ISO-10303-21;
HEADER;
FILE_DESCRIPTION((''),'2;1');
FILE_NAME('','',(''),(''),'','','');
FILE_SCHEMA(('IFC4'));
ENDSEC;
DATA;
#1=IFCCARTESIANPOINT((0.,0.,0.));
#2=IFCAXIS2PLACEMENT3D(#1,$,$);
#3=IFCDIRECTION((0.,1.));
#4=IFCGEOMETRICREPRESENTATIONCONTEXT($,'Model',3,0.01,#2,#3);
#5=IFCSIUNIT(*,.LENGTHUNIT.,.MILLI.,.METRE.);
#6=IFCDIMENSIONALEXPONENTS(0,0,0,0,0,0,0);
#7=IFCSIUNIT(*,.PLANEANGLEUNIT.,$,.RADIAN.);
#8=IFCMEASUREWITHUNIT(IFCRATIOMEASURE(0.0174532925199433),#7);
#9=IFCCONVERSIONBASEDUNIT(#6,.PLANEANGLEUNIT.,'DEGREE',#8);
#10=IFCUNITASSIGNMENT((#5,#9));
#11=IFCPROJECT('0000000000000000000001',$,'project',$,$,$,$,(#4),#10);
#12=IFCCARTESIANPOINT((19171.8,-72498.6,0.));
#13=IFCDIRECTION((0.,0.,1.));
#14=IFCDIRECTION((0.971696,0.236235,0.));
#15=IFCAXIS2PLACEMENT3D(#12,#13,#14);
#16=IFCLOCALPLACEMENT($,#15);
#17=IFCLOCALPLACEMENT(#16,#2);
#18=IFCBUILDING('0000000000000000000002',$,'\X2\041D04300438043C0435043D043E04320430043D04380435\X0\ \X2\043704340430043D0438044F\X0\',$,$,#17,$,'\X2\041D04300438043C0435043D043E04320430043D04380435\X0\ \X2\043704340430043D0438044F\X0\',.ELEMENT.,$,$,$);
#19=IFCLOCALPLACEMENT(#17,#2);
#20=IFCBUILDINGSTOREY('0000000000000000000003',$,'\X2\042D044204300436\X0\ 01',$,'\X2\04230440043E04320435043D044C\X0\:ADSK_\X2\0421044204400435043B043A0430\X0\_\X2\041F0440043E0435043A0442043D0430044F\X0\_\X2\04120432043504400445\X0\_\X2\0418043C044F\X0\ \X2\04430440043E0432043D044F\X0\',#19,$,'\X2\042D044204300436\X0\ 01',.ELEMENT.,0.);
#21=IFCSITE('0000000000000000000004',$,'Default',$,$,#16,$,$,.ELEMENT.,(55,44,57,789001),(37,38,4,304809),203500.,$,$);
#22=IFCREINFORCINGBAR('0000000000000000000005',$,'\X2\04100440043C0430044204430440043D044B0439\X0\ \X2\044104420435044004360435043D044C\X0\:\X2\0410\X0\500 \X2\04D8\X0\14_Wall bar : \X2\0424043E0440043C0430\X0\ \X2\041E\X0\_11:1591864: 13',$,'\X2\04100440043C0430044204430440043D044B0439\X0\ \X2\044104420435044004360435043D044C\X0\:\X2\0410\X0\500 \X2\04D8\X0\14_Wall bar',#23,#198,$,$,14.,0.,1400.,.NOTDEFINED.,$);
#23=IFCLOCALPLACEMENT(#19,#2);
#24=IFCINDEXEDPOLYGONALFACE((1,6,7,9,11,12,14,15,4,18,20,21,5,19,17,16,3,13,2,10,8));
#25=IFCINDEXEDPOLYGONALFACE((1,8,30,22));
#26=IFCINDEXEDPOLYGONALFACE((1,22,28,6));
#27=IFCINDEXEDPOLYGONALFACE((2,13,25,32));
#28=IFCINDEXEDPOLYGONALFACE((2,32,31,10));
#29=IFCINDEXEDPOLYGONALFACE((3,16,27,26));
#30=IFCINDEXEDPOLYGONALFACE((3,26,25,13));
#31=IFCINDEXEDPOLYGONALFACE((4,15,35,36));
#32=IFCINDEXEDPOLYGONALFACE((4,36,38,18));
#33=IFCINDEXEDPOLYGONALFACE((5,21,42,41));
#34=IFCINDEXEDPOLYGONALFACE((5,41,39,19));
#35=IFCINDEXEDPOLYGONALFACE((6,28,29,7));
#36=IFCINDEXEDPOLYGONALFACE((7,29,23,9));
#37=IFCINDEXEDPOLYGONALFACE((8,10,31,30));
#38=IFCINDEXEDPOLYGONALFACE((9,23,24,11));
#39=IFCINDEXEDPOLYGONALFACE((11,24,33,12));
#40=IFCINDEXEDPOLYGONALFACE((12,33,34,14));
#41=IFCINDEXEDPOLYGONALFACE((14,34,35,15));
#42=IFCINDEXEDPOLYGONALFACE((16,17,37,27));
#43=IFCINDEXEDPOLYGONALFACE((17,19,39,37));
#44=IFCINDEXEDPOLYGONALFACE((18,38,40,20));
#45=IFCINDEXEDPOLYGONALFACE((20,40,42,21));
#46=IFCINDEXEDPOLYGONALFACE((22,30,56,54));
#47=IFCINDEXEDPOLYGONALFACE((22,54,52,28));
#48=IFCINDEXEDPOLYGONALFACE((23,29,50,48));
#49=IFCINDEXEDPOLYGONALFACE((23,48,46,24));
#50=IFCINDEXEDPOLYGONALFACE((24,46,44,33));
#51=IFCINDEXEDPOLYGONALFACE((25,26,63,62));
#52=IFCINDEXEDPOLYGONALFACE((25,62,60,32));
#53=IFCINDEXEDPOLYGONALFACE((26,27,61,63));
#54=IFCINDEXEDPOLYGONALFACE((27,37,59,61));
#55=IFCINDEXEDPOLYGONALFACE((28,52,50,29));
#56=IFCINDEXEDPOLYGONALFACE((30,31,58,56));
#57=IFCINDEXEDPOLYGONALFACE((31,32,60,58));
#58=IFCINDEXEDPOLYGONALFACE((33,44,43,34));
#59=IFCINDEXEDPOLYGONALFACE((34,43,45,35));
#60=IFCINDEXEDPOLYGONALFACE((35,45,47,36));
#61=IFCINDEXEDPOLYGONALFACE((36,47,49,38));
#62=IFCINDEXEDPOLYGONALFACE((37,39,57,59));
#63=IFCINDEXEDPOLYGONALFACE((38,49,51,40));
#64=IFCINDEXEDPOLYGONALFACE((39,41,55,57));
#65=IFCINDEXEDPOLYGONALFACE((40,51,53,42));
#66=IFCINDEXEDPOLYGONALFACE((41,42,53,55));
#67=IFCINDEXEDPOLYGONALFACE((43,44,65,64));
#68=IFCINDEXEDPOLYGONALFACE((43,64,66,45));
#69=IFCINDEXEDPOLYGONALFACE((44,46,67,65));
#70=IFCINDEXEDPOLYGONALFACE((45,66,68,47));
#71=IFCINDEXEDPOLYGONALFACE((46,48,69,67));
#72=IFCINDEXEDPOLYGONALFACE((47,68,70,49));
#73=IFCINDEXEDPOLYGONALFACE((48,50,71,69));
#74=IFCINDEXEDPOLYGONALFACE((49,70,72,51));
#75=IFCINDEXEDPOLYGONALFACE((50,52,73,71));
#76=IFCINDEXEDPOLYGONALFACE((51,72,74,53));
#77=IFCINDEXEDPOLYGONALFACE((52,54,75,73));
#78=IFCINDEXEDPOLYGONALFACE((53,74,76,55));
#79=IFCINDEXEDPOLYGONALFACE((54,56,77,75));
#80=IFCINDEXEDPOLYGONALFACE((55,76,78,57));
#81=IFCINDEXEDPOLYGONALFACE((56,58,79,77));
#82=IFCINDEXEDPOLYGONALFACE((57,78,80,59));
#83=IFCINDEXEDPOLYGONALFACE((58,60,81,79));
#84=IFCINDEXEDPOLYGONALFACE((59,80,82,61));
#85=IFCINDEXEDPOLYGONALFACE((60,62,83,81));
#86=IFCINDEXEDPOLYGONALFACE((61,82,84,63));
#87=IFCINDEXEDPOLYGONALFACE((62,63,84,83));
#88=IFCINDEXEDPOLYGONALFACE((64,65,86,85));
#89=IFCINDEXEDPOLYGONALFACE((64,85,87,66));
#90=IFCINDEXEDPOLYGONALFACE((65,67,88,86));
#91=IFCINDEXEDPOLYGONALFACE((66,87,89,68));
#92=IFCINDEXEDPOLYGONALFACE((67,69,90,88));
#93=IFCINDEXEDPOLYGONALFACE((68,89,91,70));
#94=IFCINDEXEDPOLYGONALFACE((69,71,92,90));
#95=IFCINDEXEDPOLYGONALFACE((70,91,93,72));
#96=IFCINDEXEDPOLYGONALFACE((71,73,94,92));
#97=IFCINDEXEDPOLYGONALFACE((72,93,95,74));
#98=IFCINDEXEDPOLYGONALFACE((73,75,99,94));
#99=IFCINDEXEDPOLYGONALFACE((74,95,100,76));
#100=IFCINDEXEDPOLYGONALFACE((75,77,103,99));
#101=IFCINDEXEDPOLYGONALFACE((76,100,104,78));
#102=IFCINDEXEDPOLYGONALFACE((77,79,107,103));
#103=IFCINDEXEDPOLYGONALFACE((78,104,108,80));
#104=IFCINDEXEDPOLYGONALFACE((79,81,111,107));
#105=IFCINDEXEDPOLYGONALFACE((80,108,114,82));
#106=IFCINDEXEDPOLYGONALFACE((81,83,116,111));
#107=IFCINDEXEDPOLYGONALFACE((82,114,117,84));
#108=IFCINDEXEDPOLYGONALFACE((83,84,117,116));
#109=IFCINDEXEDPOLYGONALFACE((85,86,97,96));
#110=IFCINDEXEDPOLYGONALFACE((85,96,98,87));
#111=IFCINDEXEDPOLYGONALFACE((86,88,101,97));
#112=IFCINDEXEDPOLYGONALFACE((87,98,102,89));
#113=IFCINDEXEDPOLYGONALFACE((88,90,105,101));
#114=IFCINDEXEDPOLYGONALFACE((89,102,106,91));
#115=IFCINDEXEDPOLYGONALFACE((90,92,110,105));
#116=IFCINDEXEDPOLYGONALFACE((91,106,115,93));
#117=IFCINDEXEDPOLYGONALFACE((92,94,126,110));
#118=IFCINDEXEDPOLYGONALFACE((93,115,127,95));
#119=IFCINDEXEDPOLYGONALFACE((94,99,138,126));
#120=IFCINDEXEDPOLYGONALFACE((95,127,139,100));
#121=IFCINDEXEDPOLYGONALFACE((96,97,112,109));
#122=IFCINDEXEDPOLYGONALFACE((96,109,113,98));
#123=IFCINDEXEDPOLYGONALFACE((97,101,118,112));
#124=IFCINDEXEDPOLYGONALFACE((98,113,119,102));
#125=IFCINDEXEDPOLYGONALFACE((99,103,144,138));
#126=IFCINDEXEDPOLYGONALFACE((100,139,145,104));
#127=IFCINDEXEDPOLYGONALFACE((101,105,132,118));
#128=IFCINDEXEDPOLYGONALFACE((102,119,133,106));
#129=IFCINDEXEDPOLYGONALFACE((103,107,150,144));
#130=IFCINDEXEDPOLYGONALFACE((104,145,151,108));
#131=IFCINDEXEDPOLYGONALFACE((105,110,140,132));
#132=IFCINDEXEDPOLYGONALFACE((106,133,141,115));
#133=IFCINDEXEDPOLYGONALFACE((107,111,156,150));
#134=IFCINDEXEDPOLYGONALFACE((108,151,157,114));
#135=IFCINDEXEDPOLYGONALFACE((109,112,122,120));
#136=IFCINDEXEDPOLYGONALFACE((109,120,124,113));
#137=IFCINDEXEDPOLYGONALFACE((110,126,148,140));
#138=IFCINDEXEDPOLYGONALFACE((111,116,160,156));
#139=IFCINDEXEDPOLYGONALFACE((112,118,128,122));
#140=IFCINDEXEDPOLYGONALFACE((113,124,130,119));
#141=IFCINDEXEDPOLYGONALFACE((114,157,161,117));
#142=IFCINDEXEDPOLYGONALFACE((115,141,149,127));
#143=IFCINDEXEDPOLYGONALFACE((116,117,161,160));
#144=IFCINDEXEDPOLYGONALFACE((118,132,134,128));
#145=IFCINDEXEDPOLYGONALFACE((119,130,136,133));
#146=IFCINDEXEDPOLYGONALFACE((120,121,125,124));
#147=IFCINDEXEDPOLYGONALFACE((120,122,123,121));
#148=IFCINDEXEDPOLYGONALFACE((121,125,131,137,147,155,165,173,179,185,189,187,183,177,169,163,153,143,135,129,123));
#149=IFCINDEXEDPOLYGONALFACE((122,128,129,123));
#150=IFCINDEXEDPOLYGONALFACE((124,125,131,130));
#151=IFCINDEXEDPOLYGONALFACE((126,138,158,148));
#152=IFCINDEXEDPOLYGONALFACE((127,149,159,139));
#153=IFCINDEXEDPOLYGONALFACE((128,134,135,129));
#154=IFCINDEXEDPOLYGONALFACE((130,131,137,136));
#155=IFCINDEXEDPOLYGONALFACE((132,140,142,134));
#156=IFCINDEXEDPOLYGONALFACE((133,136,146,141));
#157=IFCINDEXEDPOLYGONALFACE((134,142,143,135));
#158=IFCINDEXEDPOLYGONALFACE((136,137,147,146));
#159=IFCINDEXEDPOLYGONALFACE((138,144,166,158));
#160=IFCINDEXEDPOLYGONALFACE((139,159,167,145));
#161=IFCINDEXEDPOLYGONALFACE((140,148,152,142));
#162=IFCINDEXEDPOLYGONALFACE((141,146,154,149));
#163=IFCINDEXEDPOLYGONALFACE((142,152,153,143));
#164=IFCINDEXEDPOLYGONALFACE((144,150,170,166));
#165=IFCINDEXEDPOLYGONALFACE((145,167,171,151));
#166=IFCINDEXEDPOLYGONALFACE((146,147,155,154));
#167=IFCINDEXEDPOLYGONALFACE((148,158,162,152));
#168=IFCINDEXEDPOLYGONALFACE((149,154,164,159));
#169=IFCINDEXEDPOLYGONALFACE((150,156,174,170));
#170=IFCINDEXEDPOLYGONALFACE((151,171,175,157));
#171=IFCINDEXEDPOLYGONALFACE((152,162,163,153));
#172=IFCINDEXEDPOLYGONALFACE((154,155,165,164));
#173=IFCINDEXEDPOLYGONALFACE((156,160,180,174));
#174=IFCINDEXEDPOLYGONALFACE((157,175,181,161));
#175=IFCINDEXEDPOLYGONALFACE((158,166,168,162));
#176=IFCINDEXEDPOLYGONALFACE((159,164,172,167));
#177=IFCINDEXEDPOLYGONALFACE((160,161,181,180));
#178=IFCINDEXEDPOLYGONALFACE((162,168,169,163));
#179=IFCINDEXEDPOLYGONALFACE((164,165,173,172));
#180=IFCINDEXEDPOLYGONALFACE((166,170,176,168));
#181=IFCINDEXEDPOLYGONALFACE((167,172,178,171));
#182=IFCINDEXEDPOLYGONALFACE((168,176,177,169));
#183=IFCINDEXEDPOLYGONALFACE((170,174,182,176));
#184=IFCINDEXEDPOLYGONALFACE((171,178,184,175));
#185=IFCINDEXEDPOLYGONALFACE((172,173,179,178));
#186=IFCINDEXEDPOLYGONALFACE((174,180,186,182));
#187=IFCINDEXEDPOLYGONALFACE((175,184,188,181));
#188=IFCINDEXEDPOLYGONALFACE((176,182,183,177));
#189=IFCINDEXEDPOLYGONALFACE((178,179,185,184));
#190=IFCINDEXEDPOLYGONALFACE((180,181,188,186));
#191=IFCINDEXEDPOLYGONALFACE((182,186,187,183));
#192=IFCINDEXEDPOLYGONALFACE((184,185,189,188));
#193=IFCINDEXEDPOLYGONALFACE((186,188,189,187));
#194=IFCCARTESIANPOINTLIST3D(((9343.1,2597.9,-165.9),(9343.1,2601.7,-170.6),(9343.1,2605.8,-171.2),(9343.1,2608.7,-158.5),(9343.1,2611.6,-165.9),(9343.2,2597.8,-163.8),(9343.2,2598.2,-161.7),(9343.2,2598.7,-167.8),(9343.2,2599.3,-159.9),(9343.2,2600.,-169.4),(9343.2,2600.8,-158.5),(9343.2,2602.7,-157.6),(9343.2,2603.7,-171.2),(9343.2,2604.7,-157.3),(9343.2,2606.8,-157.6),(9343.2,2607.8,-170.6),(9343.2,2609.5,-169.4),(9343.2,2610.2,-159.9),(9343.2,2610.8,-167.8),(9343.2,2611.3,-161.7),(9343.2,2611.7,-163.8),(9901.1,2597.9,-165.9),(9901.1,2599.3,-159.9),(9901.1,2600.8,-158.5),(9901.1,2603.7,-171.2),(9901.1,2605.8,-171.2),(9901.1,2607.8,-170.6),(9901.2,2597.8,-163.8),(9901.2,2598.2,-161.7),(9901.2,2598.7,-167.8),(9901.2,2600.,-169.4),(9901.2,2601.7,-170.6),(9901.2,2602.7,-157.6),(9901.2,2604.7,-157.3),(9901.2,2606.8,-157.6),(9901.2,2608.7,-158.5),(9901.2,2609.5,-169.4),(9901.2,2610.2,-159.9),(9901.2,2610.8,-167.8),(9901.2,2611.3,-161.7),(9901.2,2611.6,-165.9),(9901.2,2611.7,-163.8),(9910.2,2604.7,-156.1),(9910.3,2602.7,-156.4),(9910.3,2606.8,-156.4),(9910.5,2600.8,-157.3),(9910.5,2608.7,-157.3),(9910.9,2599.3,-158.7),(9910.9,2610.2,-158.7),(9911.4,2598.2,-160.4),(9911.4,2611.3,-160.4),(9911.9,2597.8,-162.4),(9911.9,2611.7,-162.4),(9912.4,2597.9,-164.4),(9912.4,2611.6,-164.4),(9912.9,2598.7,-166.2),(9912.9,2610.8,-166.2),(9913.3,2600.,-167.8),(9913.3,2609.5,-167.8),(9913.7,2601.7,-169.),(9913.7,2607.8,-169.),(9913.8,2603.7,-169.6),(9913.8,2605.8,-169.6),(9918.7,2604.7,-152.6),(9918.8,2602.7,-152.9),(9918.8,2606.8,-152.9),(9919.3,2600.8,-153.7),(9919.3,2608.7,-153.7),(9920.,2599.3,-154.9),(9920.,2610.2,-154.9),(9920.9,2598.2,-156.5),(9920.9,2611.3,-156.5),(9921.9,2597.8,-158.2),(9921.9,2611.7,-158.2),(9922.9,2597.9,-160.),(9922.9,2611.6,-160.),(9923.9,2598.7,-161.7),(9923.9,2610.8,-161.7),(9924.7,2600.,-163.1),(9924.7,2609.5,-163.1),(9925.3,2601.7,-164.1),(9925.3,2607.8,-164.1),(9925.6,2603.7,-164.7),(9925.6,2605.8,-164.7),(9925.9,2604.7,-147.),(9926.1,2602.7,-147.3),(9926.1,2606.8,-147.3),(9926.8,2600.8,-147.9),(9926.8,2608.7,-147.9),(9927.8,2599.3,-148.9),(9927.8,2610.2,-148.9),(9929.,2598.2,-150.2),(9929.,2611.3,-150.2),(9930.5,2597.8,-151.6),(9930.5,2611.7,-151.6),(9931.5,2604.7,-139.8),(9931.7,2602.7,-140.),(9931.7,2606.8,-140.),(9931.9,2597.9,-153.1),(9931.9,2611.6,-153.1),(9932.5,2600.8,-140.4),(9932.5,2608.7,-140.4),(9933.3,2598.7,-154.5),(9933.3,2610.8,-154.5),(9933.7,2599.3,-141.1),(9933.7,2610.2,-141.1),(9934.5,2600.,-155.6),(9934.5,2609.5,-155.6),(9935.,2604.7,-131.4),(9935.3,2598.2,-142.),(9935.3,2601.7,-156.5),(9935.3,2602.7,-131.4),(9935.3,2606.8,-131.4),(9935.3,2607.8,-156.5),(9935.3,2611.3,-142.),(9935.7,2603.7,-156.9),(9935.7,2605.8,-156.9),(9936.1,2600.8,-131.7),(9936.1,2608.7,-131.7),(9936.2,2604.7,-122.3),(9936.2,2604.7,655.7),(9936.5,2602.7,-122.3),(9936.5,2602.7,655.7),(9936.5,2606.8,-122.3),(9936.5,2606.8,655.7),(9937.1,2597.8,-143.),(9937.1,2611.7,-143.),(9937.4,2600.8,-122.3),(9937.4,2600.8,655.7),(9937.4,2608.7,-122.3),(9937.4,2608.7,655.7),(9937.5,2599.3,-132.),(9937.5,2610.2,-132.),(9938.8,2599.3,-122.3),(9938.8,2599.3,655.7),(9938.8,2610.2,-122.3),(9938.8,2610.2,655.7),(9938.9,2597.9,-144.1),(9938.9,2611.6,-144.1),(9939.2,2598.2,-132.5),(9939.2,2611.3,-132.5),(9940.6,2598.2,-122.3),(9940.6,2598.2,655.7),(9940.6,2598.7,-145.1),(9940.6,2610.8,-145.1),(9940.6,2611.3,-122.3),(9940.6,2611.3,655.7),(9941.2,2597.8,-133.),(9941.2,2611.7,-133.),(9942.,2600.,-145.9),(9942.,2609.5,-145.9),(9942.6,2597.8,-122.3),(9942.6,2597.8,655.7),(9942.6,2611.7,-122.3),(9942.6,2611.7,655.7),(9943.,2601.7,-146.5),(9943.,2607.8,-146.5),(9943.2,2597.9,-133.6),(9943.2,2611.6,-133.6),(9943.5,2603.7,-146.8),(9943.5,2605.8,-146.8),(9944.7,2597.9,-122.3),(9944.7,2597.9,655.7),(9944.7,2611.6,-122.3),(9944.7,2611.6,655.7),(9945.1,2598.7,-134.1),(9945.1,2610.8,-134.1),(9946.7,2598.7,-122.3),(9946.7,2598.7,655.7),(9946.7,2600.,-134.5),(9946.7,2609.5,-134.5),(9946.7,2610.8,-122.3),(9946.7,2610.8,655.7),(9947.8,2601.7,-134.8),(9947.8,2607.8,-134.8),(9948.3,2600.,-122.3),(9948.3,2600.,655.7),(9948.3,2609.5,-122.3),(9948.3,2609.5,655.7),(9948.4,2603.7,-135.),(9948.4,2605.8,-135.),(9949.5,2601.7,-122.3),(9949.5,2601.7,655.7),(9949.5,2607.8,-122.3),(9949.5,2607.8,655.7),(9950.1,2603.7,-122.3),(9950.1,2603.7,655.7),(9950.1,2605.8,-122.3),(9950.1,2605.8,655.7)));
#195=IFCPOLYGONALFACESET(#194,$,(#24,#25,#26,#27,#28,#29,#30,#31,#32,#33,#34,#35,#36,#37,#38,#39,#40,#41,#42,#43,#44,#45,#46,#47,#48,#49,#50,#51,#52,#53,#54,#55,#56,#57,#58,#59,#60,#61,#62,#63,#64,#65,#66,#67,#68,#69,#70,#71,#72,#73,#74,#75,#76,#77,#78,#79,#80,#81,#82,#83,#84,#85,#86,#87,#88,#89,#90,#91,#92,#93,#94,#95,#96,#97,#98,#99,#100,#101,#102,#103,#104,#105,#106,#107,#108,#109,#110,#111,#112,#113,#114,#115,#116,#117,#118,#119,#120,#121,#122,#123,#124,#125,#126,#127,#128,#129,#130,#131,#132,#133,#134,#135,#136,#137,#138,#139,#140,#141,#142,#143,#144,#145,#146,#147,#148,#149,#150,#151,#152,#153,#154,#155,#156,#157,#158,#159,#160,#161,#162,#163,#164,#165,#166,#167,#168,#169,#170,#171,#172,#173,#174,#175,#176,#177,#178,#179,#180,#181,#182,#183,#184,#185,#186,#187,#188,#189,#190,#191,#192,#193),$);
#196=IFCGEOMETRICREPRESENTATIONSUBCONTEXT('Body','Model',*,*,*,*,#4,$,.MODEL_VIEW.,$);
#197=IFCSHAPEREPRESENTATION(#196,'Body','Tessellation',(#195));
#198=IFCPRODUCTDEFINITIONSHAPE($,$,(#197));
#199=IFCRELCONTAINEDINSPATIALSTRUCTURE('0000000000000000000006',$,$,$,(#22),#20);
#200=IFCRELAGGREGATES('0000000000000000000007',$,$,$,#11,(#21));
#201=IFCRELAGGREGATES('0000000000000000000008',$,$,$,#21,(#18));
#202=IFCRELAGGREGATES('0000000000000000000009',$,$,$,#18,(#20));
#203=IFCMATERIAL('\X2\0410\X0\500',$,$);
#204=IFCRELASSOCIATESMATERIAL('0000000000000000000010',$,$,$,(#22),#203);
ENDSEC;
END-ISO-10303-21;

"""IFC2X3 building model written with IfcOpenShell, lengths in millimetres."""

from ifc_helpers import new_model, entity, si_unit, converted_unit, direction, frame, origin, place, context, subcontext, project, spatial, material, element, save


model = new_model("IFC2X3")

# Units and contexts
model_context = context("Model", 3, precision=0.01, world=origin(), true_north=direction((0.0, 1.0)))
body_context = subcontext(model_context, "Body", "Model", "MODEL_VIEW")
ifc_project = project(units=[si_unit("LENGTHUNIT", "METRE", prefix="MILLI"), converted_unit("PLANEANGLEUNIT", "DEGREE", entity("IfcRatioMeasure", 0.0174532925199433), si_unit("PLANEANGLEUNIT", "RADIAN"), dimensions=[0, 0, 0, 0, 0, 0, 0])], contexts=[model_context])

# Site, building, storey
site_placement = place(None, frame((19171.8, -72498.6, 0.0), z_axis=(0.0, 0.0, 1.0), x_axis=(0.971696, 0.236235, 0.0)))
site = spatial("IfcSite", under=ifc_project, at=site_placement, Name="Default", CompositionType="ELEMENT", RefLatitude=(55, 44, 57, 789001), RefLongitude=(37, 38, 4, 304809), RefElevation=203500.0)
building_placement = place(site_placement, origin())
building = spatial("IfcBuilding", under=site, at=building_placement, Name="Наименование здания", LongName="Наименование здания", CompositionType="ELEMENT")
storey_placement = place(building_placement, origin())
storey = spatial("IfcBuildingStorey", under=building, at=storey_placement, Name="Этаж 01", ObjectType="Уровень:ADSK_Стрелка_Проектная_Вверх_Имя уровня", LongName="Этаж 01", CompositionType="ELEMENT", Elevation=0.0)

# Reinforcing bar
ifc_material = material(Name="А500")
placement = place(storey_placement, origin())
element("IfcReinforcingBar", 1, at=placement, inside=storey, material=ifc_material, Name="Арматурный стержень:А500 Ә14_Wall bar : Форма О_11:1591864: 13", ObjectType="Арматурный стержень:А500 Ә14_Wall bar", BarLength=1400.0, BarRole="NOTDEFINED", CrossSectionArea=0.0, NominalDiameter=14.0, context=body_context, shape_type="AdvancedSweptSolid", body=[
    entity("IfcSweptDiskSolid", entity("IfcCompositeCurve", [entity("IfcCompositeCurveSegment", "CONTINUOUS", True, entity("IfcPolyline", [entity("IfcCartesianPoint", [9943.1, 2604.7, 655.7]), entity("IfcCartesianPoint", [9943.1, 2604.7, -122.3])])), entity("IfcCompositeCurveSegment", "CONTINUOUS", True, entity("IfcTrimmedCurve", entity("IfcCircle", entity("IfcAxis2Placement3D", entity("IfcCartesianPoint", [9901.1, 2604.7, -122.3]), entity("IfcDirection", [0.0, 1.0, 0.0]), entity("IfcDirection", [0.0, 0.0, -1.0])), 42.0), [entity("IfcParameterValue", 270.0)], [entity("IfcParameterValue", 360.0)], True, "PARAMETER")), entity("IfcCompositeCurveSegment", "CONTINUOUS", True, entity("IfcPolyline", [entity("IfcCartesianPoint", [9901.1, 2604.7, -164.3]), entity("IfcCartesianPoint", [9343.1, 2604.7, -164.3])]))], False), 7.0, None, 0.0, 92.0),
])

save(model, "model.ifc")
